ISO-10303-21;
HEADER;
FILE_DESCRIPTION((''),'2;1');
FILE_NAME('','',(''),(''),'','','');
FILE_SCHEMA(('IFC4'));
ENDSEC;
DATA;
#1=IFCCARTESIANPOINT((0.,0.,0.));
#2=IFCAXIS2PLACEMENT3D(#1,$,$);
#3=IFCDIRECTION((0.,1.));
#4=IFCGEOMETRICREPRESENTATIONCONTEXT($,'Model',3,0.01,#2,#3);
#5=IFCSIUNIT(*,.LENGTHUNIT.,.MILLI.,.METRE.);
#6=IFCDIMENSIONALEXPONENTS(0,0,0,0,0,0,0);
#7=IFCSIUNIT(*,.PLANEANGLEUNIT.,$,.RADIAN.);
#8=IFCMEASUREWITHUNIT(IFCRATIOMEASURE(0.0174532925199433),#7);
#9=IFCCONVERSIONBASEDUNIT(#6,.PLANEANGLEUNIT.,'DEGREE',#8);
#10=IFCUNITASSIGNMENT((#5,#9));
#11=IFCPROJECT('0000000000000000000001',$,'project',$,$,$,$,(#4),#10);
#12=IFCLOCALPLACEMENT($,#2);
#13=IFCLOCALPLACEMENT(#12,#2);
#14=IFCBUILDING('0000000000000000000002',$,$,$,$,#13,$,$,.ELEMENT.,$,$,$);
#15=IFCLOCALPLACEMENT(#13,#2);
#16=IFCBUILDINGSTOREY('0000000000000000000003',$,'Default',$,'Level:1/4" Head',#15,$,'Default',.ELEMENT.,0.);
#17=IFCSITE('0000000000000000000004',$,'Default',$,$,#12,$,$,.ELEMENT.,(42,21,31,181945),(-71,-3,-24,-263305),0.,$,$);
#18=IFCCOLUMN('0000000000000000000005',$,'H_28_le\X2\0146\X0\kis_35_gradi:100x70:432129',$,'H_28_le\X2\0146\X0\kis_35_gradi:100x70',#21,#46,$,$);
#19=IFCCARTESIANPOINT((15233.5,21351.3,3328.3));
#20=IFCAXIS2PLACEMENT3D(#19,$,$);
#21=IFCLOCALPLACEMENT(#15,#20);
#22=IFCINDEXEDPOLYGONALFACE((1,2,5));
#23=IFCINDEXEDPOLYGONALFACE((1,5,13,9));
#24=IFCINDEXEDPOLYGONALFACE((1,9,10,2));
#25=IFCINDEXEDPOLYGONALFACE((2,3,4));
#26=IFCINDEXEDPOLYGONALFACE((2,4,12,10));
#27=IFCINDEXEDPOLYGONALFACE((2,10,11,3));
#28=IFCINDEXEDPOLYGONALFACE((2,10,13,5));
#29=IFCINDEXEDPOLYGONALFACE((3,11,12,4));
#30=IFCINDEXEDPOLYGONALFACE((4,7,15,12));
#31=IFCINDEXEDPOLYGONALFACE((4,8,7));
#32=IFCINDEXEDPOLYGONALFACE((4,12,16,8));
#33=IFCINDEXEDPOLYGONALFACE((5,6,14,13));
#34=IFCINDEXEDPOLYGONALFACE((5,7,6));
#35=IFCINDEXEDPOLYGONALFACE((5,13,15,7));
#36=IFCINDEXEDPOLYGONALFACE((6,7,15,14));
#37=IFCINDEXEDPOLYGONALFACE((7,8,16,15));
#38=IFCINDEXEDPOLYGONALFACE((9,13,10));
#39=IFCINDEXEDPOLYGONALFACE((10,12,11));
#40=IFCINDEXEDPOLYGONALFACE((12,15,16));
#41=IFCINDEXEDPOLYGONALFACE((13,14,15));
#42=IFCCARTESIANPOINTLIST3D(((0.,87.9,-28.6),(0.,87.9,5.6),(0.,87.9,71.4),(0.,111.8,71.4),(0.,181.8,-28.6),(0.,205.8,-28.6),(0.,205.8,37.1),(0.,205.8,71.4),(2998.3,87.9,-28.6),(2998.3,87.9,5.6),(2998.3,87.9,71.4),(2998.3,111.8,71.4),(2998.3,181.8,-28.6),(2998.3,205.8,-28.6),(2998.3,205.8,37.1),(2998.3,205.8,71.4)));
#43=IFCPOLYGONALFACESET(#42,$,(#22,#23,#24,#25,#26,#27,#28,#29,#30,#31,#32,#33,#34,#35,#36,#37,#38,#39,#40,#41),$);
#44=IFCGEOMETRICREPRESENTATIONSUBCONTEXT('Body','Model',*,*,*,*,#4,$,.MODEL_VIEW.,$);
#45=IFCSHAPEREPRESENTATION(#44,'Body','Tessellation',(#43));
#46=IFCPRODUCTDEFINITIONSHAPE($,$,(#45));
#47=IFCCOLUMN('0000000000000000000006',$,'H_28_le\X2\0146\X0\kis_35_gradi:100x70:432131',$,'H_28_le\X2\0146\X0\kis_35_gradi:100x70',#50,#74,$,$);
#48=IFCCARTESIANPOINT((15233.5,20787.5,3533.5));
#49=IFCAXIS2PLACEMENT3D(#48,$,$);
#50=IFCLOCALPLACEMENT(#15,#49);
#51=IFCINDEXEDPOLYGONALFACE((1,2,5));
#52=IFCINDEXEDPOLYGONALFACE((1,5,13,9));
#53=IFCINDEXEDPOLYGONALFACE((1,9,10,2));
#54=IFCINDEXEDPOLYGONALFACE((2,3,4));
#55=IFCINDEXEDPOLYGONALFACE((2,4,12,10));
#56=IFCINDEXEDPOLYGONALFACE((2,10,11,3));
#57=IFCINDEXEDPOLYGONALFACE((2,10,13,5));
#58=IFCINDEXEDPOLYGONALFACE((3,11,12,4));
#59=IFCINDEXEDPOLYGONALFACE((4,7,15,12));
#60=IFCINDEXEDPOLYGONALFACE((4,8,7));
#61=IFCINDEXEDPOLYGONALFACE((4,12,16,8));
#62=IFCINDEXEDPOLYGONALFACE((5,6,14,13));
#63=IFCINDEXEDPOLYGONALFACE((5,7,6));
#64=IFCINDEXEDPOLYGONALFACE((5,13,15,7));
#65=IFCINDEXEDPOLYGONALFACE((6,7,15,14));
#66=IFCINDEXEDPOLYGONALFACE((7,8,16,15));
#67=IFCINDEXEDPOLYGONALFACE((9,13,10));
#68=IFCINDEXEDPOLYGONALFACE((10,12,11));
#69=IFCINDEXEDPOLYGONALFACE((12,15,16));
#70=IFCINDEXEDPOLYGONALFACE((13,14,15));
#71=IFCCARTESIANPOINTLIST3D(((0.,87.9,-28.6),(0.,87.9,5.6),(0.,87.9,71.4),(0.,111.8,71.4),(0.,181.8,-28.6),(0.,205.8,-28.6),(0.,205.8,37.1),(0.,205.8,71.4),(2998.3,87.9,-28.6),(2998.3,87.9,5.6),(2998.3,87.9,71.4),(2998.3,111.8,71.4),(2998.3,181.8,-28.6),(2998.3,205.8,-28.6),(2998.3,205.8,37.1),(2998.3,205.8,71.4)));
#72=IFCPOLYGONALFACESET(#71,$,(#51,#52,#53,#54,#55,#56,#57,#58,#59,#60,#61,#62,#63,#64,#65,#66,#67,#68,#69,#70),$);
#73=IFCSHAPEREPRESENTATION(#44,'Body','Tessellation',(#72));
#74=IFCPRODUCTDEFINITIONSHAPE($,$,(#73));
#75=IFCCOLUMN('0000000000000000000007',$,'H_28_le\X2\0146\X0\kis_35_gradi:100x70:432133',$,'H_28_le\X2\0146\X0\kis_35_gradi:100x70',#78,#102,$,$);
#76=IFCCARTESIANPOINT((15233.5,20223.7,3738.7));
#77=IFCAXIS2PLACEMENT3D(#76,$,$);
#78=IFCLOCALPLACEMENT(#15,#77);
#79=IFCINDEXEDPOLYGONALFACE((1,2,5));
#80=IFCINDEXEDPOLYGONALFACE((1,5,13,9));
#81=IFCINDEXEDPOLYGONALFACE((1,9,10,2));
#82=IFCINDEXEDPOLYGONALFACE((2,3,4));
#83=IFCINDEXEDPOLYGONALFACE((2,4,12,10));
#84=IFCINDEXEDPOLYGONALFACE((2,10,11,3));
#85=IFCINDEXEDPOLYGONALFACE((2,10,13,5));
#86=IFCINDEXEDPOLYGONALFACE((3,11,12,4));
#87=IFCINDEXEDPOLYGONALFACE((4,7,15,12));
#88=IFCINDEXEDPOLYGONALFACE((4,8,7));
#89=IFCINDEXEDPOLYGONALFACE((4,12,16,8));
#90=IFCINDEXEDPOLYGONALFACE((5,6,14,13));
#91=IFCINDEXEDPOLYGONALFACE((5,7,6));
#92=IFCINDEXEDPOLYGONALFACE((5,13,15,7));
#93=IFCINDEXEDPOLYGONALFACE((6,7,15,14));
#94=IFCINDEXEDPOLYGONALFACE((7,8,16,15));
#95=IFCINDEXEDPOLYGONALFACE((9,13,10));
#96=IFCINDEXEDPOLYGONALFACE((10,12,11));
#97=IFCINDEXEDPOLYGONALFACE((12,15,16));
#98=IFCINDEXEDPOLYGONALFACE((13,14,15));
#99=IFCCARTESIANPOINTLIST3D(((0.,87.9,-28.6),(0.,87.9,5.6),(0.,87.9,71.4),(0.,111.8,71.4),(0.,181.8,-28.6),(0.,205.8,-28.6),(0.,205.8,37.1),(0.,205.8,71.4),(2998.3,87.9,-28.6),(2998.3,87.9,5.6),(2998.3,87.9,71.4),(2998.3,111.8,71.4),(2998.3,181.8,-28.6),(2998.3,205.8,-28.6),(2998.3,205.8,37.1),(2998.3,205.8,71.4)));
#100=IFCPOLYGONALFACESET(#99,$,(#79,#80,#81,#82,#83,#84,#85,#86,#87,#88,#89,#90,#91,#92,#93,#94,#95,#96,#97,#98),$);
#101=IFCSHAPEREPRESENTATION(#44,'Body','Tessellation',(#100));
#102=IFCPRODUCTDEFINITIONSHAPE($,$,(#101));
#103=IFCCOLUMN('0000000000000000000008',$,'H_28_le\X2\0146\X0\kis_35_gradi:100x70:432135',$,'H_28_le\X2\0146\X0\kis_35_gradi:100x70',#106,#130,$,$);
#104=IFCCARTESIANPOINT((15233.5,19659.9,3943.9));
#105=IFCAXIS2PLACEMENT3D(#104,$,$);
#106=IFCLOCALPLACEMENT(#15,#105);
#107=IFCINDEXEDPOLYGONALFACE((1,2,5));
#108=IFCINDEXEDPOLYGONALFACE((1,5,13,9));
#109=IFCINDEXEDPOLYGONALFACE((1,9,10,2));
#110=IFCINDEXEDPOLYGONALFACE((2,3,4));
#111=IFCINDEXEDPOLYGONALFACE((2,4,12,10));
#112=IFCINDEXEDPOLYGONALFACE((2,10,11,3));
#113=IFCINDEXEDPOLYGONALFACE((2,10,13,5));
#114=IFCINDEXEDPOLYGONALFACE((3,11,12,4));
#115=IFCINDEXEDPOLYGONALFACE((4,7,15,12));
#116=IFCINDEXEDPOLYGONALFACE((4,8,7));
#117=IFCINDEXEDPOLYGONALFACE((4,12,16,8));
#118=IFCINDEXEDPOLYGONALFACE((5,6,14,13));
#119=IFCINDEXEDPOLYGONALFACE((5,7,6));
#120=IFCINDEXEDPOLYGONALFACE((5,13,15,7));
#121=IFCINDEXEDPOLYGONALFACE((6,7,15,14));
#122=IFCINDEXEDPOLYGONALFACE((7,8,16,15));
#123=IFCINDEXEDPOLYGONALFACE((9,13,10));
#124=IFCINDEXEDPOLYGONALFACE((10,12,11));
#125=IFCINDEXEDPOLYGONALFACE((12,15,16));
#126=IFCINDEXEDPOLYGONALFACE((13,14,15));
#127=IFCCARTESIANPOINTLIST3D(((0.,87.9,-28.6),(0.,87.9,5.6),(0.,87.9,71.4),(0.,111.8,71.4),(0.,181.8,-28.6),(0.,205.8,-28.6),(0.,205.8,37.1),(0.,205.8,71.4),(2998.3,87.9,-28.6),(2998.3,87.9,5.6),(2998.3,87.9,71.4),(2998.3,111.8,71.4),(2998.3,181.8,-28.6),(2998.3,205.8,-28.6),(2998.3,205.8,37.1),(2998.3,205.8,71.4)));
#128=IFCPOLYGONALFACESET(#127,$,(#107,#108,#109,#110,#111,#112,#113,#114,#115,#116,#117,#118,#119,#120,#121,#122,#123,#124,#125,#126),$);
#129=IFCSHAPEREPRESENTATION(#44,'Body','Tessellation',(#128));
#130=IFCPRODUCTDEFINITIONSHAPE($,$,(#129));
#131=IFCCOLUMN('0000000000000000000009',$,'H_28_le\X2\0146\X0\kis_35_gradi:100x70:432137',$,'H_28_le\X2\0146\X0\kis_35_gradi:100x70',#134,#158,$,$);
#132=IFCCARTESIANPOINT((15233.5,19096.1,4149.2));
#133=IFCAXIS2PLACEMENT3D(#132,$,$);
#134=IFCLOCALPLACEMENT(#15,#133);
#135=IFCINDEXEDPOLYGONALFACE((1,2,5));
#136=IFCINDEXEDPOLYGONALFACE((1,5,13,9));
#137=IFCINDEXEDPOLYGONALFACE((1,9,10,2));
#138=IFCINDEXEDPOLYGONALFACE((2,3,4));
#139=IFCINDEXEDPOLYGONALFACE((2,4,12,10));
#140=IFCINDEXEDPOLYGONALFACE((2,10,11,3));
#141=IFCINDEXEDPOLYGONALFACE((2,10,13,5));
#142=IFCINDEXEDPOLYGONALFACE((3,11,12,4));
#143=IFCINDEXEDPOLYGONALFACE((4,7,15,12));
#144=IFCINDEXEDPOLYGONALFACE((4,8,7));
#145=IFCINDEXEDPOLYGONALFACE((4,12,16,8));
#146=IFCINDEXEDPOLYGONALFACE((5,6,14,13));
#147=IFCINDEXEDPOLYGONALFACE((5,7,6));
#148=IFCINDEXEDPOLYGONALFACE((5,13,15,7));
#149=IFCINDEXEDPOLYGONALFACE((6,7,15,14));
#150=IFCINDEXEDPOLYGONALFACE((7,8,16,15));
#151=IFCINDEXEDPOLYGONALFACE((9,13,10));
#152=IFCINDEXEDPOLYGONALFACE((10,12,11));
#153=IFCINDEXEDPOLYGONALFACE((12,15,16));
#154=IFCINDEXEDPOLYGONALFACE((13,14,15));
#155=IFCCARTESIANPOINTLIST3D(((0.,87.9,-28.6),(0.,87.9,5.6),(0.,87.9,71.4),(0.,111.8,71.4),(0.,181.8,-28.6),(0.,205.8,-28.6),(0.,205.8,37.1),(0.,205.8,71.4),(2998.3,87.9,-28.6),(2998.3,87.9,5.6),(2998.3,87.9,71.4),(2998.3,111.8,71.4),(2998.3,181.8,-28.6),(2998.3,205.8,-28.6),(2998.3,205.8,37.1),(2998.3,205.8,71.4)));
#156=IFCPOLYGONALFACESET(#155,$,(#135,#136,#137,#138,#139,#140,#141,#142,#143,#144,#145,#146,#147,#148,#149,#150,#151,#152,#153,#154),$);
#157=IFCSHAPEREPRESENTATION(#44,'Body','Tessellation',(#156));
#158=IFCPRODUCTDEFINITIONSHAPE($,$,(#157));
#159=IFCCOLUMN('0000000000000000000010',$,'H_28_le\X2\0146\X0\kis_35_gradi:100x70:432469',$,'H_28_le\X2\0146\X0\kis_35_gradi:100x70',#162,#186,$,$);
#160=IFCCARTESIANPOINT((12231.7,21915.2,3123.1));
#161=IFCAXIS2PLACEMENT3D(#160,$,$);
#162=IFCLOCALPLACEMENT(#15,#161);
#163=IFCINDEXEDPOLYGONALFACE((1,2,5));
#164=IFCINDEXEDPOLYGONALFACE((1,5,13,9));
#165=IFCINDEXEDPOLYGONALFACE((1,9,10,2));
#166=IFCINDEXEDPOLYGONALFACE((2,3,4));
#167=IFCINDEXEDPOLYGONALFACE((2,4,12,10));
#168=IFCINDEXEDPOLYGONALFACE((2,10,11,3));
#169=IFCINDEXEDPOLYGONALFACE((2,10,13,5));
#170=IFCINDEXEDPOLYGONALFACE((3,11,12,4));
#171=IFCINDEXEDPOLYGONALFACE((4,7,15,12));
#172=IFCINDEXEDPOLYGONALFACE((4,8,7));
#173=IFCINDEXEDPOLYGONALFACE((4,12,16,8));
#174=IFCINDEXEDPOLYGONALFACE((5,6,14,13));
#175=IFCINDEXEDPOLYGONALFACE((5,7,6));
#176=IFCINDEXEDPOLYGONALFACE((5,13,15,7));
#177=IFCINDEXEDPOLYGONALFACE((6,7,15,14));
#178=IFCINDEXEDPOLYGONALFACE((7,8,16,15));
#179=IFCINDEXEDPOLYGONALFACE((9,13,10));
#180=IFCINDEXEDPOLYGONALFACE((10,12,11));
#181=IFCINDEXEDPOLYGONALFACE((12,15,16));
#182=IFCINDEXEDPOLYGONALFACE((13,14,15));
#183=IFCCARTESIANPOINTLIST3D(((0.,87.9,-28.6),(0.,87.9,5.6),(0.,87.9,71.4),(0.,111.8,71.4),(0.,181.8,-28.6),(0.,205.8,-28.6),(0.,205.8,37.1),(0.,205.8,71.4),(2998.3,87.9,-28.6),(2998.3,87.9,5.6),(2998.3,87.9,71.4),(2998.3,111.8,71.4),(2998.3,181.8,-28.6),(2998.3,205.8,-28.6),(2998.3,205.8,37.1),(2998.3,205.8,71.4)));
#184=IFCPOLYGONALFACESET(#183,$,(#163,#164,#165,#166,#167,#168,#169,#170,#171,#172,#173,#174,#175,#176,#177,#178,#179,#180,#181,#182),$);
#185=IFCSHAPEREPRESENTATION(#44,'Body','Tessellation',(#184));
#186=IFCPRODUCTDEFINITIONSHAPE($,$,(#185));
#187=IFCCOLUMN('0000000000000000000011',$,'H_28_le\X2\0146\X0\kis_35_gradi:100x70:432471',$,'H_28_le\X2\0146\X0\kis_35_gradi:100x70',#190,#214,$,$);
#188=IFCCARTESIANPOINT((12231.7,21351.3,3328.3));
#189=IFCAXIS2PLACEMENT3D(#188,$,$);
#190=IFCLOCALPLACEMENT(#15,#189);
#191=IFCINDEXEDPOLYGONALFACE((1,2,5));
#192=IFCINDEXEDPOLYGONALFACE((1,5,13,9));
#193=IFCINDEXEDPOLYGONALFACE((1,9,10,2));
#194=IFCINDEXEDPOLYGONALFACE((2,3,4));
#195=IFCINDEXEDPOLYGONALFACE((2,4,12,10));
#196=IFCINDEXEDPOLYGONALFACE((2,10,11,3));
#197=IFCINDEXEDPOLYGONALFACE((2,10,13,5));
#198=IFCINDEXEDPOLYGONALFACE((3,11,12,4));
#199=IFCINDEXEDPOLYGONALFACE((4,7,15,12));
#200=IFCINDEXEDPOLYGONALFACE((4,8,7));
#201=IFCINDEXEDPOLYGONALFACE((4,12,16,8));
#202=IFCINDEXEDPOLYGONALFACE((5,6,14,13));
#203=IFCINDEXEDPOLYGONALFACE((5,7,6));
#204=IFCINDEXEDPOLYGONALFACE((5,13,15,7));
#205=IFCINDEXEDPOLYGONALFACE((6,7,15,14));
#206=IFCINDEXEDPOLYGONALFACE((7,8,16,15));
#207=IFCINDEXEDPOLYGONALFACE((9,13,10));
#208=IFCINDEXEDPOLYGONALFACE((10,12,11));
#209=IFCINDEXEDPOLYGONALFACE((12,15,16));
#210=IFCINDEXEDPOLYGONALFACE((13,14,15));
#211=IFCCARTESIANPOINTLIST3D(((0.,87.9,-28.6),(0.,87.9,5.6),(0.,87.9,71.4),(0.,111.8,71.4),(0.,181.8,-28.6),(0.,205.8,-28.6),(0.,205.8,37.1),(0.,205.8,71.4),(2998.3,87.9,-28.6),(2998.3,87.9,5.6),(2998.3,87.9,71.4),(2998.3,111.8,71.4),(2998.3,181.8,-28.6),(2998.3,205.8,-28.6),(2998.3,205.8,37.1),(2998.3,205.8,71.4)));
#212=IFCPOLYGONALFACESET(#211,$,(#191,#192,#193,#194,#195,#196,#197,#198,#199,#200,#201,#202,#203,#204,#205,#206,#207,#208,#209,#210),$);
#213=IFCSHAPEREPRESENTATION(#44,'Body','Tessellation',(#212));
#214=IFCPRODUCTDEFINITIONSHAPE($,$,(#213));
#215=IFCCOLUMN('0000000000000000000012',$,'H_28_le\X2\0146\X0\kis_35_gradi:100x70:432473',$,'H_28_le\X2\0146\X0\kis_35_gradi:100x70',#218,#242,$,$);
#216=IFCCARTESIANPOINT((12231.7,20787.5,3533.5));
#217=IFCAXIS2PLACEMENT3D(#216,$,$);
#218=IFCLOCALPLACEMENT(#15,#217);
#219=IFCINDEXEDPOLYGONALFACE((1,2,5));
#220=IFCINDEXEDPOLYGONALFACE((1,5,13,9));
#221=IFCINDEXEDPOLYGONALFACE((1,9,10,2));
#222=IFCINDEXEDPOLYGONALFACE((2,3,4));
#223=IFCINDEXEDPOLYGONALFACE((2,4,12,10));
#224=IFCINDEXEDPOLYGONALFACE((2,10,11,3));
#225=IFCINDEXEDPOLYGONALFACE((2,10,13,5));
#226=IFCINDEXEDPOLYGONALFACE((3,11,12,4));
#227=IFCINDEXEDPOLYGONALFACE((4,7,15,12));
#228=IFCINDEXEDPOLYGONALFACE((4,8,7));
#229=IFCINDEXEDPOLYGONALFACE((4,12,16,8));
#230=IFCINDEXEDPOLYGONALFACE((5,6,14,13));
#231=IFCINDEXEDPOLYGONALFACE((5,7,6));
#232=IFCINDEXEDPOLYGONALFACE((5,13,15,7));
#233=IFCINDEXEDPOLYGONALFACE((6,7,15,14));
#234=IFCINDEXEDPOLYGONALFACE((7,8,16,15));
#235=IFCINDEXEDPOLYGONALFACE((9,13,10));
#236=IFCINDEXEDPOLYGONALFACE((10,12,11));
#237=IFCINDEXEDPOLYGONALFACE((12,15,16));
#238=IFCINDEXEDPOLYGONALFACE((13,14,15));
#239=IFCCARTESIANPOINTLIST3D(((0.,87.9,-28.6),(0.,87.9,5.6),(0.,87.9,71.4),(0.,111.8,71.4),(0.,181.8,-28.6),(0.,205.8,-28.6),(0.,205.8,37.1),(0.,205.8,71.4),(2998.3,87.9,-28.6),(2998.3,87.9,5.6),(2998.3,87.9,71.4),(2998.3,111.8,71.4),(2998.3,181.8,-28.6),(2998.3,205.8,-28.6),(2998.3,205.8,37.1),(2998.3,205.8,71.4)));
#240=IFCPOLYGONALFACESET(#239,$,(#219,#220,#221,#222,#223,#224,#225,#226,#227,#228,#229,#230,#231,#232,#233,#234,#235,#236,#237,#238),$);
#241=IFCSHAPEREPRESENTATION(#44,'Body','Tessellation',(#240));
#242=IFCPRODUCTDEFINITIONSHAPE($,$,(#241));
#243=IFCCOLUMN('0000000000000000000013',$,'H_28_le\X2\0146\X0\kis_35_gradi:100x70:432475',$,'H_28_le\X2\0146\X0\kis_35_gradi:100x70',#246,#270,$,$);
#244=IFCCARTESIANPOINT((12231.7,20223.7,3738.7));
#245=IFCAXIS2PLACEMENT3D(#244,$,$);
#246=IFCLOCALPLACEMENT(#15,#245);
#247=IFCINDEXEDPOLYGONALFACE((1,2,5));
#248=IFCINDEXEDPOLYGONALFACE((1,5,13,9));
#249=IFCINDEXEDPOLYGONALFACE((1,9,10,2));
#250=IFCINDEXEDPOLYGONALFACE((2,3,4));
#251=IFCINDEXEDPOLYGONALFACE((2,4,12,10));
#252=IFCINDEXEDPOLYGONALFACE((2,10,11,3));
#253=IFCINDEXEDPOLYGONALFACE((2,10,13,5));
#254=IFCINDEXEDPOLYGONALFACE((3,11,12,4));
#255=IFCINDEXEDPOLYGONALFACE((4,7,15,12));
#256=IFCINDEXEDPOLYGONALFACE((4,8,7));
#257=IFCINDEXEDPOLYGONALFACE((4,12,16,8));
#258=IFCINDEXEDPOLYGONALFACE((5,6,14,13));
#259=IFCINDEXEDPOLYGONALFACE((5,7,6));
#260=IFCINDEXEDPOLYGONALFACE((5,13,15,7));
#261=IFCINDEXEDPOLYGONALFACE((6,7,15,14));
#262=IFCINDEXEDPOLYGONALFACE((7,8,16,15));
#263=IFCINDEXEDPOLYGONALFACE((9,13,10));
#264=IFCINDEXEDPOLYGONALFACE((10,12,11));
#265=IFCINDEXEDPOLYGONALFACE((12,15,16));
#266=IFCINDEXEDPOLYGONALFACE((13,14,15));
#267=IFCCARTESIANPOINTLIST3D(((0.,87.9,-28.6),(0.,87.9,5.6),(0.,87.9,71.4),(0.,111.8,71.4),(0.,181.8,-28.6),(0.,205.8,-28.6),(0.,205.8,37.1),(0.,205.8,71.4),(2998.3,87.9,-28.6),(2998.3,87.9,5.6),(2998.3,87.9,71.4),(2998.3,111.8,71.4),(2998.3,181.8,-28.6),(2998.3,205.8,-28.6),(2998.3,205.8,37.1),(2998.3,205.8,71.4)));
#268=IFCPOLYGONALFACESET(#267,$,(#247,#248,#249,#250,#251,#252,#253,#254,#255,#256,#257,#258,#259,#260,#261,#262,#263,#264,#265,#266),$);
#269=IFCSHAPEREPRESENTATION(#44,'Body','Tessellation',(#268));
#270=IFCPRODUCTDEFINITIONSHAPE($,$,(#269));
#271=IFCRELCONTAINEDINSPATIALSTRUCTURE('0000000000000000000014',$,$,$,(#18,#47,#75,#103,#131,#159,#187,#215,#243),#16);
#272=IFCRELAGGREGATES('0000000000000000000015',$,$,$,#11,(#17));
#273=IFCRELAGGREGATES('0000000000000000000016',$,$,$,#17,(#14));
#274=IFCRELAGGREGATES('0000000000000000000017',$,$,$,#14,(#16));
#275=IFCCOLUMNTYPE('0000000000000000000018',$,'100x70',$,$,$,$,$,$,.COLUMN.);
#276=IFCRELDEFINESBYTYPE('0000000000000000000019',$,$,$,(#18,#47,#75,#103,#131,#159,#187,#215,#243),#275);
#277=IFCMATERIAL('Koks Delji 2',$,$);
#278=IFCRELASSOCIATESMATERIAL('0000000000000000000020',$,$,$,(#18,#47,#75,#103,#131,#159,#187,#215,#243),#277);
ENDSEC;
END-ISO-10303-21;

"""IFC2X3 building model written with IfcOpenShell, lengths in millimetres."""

from ifc_helpers import new_model, entity, si_unit, converted_unit, direction, frame, frame_2d, origin, place, context, subcontext, project, spatial, rectangle, extrude, boolean, source, transform, mapped, material, type_object, type_shapes, element, save


model = new_model("IFC2X3")

# Units and contexts
model_context = context("Model", 3, precision=0.01, world=origin(), true_north=direction((0.0, 1.0)))
body_context = subcontext(model_context, "Body", "Model", "MODEL_VIEW")
ifc_project = project(units=[si_unit("LENGTHUNIT", "METRE", prefix="MILLI"), converted_unit("PLANEANGLEUNIT", "DEGREE", entity("IfcRatioMeasure", 0.0174532925199433), si_unit("PLANEANGLEUNIT", "RADIAN"), dimensions=[0, 0, 0, 0, 0, 0, 0])], contexts=[model_context])

# Site, building, storey
site_placement = place(None, origin())
site = spatial("IfcSite", under=ifc_project, at=site_placement, Name="Default", CompositionType="ELEMENT", RefLatitude=(42, 21, 31, 181945), RefLongitude=(-71, -3, -24, -263305), RefElevation=0.0)
building_placement = place(site_placement, origin())
building = spatial("IfcBuilding", under=site, at=building_placement, CompositionType="ELEMENT")
storey_placement = place(building_placement, origin())
storey = spatial("IfcBuildingStorey", under=building, at=storey_placement, Name="Default", ObjectType="Level:1/4\" Head", LongName="Default", CompositionType="ELEMENT", Elevation=0.0)

# Columns
ifc_material_1 = material(Name="Koks Delji 2")
column_type = type_object("IfcColumnType", Name="100x70", PredefinedType="COLUMN")
shared_shape_1 = source(origin(), body_context, "Body", "CSG", [
    boolean("DIFFERENCE", extrude(rectangle(XDim=2998.3, YDim=117.9, at=frame_2d((0.0, 0.0), x_axis=(1.0, 0.0))), frame((1499.1, 146.8, -28.6)), (0.0, 0.0, 1.0), 100.0), extrude(rectangle(XDim=70.0, YDim=100.0, at=frame_2d((0.0, 0.0), x_axis=(0.0, 1.0))), frame((2998.3, 146.8, 21.4), z_axis=(1.0, 0.0, 0.0), x_axis=(0.0, 0.939693, -0.34202)), (0.0, 0.0, -1.0), 2998.3)),
])
type_shapes(column_type, [shared_shape_1])
for number, where, name in (
    (1, (15233.5, 21351.3, 3328.3), "H_28_leņkis_35_gradi:100x70:432129"),
    (2, (15233.5, 20787.5, 3533.5), "H_28_leņkis_35_gradi:100x70:432131"),
    (3, (15233.5, 20223.7, 3738.7), "H_28_leņkis_35_gradi:100x70:432133"),
    (4, (15233.5, 19659.9, 3943.9), "H_28_leņkis_35_gradi:100x70:432135"),
    (5, (15233.5, 19096.1, 4149.2), "H_28_leņkis_35_gradi:100x70:432137"),
    (6, (12231.7, 21915.2, 3123.1), "H_28_leņkis_35_gradi:100x70:432469"),
    (7, (12231.7, 21351.3, 3328.3), "H_28_leņkis_35_gradi:100x70:432471"),
    (8, (12231.7, 20787.5, 3533.5), "H_28_leņkis_35_gradi:100x70:432473"),
    (9, (12231.7, 20223.7, 3738.7), "H_28_leņkis_35_gradi:100x70:432475"),
):
    element("IfcColumn", number, at=place(storey_placement, frame(where)), inside=storey, type_object=column_type, material=ifc_material_1, Name=name, ObjectType="H_28_leņkis_35_gradi:100x70", context=body_context, shape_type="MappedRepresentation", body=[
        mapped(shared_shape_1, transform((0.0, 0.0, 0.0), scale=1.0)),
    ])

save(model, "model.ifc")
